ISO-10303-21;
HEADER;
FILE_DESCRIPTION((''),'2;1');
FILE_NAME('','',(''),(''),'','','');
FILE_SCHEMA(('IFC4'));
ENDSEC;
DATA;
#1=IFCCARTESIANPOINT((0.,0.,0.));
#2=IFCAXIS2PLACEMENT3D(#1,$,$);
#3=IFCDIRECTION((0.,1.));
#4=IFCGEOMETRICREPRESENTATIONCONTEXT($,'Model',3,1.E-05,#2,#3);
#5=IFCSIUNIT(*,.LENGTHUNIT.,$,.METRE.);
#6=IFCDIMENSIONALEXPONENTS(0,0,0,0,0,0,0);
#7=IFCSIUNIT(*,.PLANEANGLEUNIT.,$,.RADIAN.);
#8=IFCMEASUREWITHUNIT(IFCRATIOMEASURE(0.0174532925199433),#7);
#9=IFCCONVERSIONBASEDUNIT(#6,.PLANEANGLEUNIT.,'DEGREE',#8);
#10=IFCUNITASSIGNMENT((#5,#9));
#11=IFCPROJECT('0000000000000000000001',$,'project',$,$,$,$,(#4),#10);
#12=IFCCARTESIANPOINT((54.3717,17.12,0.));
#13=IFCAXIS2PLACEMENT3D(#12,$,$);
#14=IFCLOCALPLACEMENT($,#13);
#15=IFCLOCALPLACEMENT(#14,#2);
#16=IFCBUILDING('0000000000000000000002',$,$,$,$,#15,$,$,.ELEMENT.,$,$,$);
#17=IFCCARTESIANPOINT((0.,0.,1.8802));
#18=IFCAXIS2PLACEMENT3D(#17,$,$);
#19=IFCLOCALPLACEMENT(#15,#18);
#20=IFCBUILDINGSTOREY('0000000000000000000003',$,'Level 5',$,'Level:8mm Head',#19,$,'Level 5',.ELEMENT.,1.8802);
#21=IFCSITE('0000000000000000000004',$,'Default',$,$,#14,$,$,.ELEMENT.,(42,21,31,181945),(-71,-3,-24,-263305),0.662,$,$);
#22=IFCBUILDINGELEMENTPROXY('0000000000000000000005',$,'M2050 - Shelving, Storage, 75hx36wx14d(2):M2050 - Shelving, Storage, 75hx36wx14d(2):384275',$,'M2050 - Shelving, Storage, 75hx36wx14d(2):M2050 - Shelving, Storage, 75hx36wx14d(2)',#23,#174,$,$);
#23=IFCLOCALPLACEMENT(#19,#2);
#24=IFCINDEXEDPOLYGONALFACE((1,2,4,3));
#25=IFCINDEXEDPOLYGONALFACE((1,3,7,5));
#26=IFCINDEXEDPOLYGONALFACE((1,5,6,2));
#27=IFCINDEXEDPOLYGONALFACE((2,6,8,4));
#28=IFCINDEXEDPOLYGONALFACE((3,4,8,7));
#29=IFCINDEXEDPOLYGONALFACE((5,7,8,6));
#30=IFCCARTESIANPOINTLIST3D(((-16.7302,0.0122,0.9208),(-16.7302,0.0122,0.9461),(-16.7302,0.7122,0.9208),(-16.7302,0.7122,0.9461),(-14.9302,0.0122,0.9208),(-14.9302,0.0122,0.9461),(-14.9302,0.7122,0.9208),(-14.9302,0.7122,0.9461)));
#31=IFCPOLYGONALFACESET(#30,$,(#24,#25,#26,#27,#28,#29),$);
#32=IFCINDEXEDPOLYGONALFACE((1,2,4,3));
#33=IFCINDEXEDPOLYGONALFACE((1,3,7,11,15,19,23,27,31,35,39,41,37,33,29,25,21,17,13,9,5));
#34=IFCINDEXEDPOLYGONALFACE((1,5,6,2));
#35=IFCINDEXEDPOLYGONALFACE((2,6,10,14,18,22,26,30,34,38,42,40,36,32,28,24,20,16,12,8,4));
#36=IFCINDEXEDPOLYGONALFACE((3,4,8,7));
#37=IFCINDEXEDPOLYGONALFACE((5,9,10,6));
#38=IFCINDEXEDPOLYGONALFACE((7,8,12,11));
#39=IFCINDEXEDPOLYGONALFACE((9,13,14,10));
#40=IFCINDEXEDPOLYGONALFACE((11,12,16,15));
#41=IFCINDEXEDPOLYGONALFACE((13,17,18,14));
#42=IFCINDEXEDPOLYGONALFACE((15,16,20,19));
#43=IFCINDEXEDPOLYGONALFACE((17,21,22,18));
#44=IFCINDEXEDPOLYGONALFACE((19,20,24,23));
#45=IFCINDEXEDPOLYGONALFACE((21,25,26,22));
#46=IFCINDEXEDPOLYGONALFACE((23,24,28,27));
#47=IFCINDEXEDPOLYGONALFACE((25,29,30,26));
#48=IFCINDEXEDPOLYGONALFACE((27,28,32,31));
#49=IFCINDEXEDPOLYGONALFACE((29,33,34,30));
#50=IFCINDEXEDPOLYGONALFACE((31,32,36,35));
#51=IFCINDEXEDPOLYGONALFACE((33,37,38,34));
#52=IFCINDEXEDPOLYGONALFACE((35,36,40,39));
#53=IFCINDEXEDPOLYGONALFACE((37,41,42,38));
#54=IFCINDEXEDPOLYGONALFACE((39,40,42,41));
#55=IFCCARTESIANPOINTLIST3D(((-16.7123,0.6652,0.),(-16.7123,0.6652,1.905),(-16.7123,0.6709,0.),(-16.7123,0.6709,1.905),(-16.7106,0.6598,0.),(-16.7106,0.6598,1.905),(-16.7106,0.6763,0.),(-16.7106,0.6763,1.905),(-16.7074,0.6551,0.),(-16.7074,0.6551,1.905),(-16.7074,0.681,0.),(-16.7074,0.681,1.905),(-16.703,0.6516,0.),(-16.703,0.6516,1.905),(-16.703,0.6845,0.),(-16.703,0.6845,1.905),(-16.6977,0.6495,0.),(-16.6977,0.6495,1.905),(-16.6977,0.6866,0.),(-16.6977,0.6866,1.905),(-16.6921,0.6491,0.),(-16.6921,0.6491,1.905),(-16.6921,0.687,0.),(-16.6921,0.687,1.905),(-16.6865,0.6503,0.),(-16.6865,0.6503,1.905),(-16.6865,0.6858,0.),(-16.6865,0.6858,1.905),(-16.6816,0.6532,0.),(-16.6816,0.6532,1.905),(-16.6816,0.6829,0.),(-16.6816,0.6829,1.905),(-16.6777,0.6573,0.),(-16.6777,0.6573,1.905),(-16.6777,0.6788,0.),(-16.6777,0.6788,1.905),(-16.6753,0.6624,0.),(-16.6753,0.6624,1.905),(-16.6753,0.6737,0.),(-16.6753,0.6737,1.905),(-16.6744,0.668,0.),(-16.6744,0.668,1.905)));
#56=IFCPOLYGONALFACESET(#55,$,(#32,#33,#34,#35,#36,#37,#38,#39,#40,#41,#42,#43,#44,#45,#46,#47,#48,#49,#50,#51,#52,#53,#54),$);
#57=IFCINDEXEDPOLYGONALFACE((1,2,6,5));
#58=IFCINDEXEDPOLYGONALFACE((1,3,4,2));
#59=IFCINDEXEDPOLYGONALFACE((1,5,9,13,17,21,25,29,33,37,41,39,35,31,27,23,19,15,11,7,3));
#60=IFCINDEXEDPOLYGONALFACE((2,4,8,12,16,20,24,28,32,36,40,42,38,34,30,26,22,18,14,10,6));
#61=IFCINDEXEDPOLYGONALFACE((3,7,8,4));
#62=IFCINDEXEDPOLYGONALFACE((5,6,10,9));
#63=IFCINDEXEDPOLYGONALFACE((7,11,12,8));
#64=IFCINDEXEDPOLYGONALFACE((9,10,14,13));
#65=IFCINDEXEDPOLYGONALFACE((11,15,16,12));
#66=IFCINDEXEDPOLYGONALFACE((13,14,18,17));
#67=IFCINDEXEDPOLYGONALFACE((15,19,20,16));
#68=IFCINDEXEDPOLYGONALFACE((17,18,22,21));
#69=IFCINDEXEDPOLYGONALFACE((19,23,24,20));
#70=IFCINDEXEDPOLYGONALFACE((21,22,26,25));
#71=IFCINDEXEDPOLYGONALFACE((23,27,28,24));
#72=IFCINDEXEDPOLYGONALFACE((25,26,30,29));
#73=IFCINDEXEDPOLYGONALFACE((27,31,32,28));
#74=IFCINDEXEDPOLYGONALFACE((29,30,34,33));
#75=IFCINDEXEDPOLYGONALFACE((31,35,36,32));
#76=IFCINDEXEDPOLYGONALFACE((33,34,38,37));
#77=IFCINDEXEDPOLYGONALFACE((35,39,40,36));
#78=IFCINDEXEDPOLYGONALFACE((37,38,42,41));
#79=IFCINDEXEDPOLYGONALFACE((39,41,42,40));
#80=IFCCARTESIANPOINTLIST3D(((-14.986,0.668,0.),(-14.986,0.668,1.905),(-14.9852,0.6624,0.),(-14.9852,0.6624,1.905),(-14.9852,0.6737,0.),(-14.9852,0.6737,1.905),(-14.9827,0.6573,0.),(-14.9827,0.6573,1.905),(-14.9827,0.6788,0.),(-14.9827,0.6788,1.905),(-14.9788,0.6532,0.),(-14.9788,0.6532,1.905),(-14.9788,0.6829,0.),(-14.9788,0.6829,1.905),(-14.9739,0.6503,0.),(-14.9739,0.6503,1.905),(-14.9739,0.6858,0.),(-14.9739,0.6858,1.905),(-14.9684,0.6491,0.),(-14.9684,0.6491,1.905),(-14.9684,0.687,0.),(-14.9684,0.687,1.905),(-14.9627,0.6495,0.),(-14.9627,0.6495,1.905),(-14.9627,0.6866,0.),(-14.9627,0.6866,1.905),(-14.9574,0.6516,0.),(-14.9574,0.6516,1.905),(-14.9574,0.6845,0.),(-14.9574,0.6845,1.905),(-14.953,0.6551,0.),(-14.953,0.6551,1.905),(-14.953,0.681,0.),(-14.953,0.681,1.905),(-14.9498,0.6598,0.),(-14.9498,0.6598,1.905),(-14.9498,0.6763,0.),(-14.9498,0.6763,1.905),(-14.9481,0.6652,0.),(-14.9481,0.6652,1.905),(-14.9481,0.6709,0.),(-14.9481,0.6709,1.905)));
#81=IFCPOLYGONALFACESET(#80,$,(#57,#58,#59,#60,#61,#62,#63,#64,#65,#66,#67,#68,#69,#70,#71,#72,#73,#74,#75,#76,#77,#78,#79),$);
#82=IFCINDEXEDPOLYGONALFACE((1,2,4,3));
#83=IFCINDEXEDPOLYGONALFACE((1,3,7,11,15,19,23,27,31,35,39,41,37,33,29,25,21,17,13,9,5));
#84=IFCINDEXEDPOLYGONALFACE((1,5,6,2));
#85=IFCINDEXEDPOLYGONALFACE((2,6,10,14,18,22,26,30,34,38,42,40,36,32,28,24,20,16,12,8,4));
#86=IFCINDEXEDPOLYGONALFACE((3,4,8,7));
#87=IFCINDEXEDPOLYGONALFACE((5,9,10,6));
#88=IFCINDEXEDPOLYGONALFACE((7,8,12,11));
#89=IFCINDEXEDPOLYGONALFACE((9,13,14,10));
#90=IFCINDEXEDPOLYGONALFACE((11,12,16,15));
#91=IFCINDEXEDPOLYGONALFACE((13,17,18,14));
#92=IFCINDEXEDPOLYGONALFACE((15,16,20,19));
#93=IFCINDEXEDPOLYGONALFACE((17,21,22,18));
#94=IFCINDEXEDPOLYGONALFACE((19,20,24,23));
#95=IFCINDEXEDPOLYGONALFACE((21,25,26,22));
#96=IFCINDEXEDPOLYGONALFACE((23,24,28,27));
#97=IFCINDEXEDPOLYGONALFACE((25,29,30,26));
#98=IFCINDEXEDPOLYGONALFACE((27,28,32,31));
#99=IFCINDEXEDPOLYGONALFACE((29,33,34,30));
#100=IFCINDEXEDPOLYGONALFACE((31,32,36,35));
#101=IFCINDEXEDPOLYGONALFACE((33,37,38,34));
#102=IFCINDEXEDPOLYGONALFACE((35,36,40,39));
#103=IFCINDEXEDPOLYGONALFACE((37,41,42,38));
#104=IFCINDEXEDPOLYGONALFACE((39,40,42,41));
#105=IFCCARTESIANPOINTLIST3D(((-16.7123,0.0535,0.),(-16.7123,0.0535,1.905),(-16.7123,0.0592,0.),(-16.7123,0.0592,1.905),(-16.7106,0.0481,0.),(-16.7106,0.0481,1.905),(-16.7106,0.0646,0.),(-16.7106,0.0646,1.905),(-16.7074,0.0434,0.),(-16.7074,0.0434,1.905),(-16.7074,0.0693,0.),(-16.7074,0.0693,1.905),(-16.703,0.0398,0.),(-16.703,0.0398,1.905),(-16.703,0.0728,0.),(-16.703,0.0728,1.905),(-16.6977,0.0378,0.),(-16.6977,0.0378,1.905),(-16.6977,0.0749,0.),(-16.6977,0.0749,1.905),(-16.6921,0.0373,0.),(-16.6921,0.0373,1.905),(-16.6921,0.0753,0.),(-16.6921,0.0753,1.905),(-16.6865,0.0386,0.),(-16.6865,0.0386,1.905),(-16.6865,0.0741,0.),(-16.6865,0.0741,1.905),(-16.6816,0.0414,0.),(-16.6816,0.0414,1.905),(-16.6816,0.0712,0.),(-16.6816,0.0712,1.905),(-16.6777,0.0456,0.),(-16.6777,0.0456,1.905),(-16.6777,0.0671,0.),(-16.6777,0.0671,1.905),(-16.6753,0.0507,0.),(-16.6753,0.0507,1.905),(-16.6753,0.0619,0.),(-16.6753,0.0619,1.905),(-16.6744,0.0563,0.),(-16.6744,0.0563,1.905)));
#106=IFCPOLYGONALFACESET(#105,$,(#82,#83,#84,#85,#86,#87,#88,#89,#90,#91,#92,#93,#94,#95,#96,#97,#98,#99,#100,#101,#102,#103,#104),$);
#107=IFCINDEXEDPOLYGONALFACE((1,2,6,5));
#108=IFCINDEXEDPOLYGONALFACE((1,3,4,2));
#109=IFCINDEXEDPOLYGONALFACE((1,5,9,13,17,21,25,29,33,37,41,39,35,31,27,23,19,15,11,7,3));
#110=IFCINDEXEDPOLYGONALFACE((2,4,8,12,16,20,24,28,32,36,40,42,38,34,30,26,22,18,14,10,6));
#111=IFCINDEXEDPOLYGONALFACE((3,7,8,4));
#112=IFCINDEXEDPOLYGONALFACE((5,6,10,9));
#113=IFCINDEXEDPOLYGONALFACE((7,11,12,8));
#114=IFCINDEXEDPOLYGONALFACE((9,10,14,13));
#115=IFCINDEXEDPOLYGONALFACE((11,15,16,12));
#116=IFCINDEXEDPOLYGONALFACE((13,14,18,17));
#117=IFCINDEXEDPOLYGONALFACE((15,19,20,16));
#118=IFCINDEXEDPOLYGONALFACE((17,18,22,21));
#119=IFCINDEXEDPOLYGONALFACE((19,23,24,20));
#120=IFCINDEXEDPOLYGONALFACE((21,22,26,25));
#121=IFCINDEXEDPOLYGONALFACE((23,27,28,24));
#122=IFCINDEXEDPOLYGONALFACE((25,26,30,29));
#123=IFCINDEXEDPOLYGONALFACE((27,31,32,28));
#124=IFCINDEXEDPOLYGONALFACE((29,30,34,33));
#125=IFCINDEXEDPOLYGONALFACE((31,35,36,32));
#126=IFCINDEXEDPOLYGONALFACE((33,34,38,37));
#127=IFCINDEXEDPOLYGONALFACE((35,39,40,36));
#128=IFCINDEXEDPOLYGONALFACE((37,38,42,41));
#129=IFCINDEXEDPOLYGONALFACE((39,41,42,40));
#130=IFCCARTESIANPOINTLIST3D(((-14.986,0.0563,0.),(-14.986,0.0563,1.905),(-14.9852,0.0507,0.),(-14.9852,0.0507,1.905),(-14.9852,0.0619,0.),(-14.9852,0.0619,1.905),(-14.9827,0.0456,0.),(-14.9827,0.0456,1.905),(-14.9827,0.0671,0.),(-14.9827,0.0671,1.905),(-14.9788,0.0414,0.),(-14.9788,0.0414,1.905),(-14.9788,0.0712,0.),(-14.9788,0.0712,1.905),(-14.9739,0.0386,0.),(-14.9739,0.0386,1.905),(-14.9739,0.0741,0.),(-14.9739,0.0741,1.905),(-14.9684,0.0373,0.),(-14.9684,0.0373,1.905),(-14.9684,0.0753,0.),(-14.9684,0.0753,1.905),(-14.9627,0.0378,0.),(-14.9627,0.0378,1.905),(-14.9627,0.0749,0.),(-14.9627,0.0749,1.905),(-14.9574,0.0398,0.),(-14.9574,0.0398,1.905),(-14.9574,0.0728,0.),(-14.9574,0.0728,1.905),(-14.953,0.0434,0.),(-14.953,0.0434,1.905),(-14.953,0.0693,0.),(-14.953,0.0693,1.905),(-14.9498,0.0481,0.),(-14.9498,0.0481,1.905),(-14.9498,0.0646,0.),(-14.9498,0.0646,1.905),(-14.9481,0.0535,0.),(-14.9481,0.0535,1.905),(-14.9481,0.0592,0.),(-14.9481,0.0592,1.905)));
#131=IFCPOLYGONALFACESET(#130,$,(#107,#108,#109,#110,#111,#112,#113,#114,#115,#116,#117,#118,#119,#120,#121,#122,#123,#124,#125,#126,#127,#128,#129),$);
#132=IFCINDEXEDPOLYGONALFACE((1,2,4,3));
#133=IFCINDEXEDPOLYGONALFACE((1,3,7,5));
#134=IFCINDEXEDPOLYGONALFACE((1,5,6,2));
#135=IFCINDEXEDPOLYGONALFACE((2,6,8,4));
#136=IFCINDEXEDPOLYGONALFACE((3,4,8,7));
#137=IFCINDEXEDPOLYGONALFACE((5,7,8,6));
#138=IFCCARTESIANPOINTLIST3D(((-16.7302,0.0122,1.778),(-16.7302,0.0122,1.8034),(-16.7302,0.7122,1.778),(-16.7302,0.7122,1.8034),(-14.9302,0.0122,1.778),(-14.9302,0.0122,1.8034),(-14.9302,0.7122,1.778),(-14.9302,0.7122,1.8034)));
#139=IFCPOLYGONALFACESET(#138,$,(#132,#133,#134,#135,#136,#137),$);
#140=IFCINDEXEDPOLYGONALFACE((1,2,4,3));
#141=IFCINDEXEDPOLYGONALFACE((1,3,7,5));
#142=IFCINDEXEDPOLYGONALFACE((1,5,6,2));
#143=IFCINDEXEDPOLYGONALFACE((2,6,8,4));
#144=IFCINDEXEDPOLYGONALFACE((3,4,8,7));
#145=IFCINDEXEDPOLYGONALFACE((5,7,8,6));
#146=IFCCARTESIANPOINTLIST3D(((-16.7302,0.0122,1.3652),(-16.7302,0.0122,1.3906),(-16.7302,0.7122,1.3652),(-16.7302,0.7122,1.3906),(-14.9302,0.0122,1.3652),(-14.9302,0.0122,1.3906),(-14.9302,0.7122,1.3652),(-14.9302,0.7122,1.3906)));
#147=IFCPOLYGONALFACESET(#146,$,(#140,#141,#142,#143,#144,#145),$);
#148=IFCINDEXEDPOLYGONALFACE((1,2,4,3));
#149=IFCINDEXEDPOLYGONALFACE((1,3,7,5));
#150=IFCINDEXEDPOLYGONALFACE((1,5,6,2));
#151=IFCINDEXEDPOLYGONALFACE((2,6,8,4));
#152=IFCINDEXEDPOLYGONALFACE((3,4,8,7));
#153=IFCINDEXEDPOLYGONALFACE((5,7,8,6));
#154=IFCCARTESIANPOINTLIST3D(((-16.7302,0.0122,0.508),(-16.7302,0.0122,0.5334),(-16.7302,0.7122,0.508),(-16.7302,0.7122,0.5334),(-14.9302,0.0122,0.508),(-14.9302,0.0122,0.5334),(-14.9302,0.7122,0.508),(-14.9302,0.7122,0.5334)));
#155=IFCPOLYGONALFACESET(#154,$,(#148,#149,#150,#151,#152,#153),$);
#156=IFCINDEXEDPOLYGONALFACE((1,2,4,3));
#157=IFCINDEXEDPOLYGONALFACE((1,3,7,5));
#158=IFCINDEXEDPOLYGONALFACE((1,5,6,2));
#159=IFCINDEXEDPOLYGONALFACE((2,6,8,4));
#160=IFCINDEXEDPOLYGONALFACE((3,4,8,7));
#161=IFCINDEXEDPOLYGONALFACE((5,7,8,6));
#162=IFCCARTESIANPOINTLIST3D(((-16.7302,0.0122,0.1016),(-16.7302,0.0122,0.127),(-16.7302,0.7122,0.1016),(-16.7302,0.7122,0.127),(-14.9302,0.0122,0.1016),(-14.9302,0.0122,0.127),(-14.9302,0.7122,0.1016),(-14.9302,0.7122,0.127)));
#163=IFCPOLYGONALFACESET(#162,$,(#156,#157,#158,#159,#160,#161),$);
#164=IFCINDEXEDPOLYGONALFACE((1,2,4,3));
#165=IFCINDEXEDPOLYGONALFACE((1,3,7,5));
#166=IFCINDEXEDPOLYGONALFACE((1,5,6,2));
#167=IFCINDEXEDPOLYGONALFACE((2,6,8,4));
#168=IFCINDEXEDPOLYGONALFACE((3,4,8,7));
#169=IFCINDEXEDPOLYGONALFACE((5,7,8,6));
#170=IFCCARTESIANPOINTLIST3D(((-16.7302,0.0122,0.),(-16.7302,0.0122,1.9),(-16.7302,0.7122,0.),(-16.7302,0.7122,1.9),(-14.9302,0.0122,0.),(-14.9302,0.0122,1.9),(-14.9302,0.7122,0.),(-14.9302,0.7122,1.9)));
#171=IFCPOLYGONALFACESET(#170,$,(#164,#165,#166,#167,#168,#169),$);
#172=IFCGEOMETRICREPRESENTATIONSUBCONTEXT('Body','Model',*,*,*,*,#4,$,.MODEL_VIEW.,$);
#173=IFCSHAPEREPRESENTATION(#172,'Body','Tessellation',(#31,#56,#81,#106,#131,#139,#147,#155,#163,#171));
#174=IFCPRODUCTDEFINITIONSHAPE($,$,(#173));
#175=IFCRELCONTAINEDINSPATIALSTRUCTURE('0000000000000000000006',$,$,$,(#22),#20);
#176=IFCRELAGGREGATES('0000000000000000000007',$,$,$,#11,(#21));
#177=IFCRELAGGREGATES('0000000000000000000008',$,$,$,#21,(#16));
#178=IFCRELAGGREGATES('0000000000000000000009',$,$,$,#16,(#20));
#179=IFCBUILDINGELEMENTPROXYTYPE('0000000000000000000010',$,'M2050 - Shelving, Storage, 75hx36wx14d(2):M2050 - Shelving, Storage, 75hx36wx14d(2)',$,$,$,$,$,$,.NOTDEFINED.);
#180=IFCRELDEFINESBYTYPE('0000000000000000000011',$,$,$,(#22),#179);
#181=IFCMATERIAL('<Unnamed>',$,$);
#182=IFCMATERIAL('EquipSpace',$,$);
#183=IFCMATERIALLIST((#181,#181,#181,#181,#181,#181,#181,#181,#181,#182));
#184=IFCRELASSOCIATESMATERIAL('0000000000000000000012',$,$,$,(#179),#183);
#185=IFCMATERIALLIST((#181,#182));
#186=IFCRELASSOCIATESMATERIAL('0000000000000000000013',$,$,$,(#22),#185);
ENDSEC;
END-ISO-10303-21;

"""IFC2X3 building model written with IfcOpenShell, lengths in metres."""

from ifc_helpers import new_model, entity, si_unit, converted_unit, direction, frame, frame_2d, origin, origin_2d_with_axis, place, context, subcontext, project, spatial, rectangle, circle, extrude, source, transform, mapped, material, material_list, type_object, type_shapes, element, save


model = new_model("IFC2X3")

# Units and contexts
model_context = context("Model", 3, precision=1e-05, world=origin(), true_north=direction((0.0, 1.0)))
body_context = subcontext(model_context, "Body", "Model", "MODEL_VIEW")
ifc_project = project(units=[si_unit("LENGTHUNIT", "METRE"), converted_unit("PLANEANGLEUNIT", "DEGREE", entity("IfcRatioMeasure", 0.0174532925199433), si_unit("PLANEANGLEUNIT", "RADIAN"), dimensions=[0, 0, 0, 0, 0, 0, 0])], contexts=[model_context])

# Site, building, storey
site_placement = place(None, frame((54.3717, 17.12, 0.0)))
site = spatial("IfcSite", under=ifc_project, at=site_placement, Name="Default", CompositionType="ELEMENT", RefLatitude=(42, 21, 31, 181945), RefLongitude=(-71, -3, -24, -263305), RefElevation=0.662)
building_placement = place(site_placement, origin())
building = spatial("IfcBuilding", under=site, at=building_placement, CompositionType="ELEMENT")
storey_placement = place(building_placement, frame((0.0, 0.0, 1.8802)))
storey = spatial("IfcBuildingStorey", under=building, at=storey_placement, Name="Level 5", ObjectType="Level:8mm Head", LongName="Level 5", CompositionType="ELEMENT", Elevation=1.8802)

# Building element proxy
ifc_material_1 = material(Name="<Unnamed>")
ifc_material_2 = material(Name="EquipSpace")
ifc_material_list_1 = material_list([ifc_material_1, ifc_material_1, ifc_material_1, ifc_material_1, ifc_material_1, ifc_material_1, ifc_material_1, ifc_material_1, ifc_material_1, ifc_material_2])
building_element_proxy_type = type_object("IfcBuildingElementProxyType", Name="M2050 - Shelving, Storage, 75hx36wx14d(2):M2050 - Shelving, Storage, 75hx36wx14d(2)", PredefinedType="NOTDEFINED", material=ifc_material_list_1)
shared_shape = source(origin(), body_context, "Body", "SweptSolid", [
    extrude(rectangle(XDim=1.8, YDim=0.7, at=origin_2d_with_axis()), frame((0.0, 0.0, 0.9207), z_axis=(0.0, 0.0, 1.0), x_axis=(-1.0, 0.0, 0.0)), (0.0, 0.0, 1.0), 0.0254),
    extrude(circle(Radius=0.0191, at=origin_2d_with_axis()), frame((0.8633, -0.3059, 0.0), z_axis=(0.0, 0.0, 1.0), x_axis=(-1.0, 0.0, 0.0)), (0.0, 0.0, 1.0), 1.905),
    extrude(circle(Radius=0.0191, at=origin_2d_with_axis()), frame((-0.8633, -0.3059, 0.0)), (0.0, 0.0, 1.0), 1.905),
    extrude(circle(Radius=0.0191, at=origin_2d_with_axis()), frame((0.8633, 0.3059, 0.0), z_axis=(0.0, 0.0, 1.0), x_axis=(-1.0, 0.0, 0.0)), (0.0, 0.0, 1.0), 1.905),
    extrude(circle(Radius=0.0191, at=origin_2d_with_axis()), frame((-0.8633, 0.3059, 0.0)), (0.0, 0.0, 1.0), 1.905),
    extrude(rectangle(XDim=1.8, YDim=0.7, at=origin_2d_with_axis()), frame((0.0, 0.0, 1.778), z_axis=(0.0, 0.0, 1.0), x_axis=(-1.0, 0.0, 0.0)), (0.0, 0.0, 1.0), 0.0254),
    extrude(rectangle(XDim=1.8, YDim=0.7, at=origin_2d_with_axis()), frame((0.0, 0.0, 1.3653), z_axis=(0.0, 0.0, 1.0), x_axis=(-1.0, 0.0, 0.0)), (0.0, 0.0, 1.0), 0.0254),
    extrude(rectangle(XDim=1.8, YDim=0.7, at=origin_2d_with_axis()), frame((0.0, 0.0, 0.508), z_axis=(0.0, 0.0, 1.0), x_axis=(-1.0, 0.0, 0.0)), (0.0, 0.0, 1.0), 0.0254),
    extrude(rectangle(XDim=1.8, YDim=0.7, at=origin_2d_with_axis()), frame((0.0, 0.0, 0.1016), z_axis=(0.0, 0.0, 1.0), x_axis=(-1.0, 0.0, 0.0)), (0.0, 0.0, 1.0), 0.0254),
    extrude(rectangle(XDim=0.7, YDim=1.8, at=frame_2d((0.0, 0.18), x_axis=(1.0, 0.0))), frame((-0.18, 0.0, 0.0), z_axis=(0.0, 0.0, 1.0), x_axis=(0.0, -1.0, 0.0)), (0.0, 0.0, 1.0), 1.9),
])
type_shapes(building_element_proxy_type, [shared_shape])
ifc_material_list_2 = material_list([ifc_material_1, ifc_material_2])
proxy_1_placement = place(storey_placement, frame((-15.8302, 0.3622, 0.0), z_axis=(0.0, 0.0, 1.0), x_axis=(-1.0, 0.0, 0.0)))
element("IfcBuildingElementProxy", 1, at=proxy_1_placement, inside=storey, type_object=building_element_proxy_type, material=ifc_material_list_2, Name="M2050 - Shelving, Storage, 75hx36wx14d(2):M2050 - Shelving, Storage, 75hx36wx14d(2):384275", ObjectType="M2050 - Shelving, Storage, 75hx36wx14d(2):M2050 - Shelving, Storage, 75hx36wx14d(2)", context=body_context, shape_type="MappedRepresentation", body=[
    mapped(shared_shape, transform((0.0, 0.0, 0.0), scale=1.0)),
])

save(model, "model.ifc")
